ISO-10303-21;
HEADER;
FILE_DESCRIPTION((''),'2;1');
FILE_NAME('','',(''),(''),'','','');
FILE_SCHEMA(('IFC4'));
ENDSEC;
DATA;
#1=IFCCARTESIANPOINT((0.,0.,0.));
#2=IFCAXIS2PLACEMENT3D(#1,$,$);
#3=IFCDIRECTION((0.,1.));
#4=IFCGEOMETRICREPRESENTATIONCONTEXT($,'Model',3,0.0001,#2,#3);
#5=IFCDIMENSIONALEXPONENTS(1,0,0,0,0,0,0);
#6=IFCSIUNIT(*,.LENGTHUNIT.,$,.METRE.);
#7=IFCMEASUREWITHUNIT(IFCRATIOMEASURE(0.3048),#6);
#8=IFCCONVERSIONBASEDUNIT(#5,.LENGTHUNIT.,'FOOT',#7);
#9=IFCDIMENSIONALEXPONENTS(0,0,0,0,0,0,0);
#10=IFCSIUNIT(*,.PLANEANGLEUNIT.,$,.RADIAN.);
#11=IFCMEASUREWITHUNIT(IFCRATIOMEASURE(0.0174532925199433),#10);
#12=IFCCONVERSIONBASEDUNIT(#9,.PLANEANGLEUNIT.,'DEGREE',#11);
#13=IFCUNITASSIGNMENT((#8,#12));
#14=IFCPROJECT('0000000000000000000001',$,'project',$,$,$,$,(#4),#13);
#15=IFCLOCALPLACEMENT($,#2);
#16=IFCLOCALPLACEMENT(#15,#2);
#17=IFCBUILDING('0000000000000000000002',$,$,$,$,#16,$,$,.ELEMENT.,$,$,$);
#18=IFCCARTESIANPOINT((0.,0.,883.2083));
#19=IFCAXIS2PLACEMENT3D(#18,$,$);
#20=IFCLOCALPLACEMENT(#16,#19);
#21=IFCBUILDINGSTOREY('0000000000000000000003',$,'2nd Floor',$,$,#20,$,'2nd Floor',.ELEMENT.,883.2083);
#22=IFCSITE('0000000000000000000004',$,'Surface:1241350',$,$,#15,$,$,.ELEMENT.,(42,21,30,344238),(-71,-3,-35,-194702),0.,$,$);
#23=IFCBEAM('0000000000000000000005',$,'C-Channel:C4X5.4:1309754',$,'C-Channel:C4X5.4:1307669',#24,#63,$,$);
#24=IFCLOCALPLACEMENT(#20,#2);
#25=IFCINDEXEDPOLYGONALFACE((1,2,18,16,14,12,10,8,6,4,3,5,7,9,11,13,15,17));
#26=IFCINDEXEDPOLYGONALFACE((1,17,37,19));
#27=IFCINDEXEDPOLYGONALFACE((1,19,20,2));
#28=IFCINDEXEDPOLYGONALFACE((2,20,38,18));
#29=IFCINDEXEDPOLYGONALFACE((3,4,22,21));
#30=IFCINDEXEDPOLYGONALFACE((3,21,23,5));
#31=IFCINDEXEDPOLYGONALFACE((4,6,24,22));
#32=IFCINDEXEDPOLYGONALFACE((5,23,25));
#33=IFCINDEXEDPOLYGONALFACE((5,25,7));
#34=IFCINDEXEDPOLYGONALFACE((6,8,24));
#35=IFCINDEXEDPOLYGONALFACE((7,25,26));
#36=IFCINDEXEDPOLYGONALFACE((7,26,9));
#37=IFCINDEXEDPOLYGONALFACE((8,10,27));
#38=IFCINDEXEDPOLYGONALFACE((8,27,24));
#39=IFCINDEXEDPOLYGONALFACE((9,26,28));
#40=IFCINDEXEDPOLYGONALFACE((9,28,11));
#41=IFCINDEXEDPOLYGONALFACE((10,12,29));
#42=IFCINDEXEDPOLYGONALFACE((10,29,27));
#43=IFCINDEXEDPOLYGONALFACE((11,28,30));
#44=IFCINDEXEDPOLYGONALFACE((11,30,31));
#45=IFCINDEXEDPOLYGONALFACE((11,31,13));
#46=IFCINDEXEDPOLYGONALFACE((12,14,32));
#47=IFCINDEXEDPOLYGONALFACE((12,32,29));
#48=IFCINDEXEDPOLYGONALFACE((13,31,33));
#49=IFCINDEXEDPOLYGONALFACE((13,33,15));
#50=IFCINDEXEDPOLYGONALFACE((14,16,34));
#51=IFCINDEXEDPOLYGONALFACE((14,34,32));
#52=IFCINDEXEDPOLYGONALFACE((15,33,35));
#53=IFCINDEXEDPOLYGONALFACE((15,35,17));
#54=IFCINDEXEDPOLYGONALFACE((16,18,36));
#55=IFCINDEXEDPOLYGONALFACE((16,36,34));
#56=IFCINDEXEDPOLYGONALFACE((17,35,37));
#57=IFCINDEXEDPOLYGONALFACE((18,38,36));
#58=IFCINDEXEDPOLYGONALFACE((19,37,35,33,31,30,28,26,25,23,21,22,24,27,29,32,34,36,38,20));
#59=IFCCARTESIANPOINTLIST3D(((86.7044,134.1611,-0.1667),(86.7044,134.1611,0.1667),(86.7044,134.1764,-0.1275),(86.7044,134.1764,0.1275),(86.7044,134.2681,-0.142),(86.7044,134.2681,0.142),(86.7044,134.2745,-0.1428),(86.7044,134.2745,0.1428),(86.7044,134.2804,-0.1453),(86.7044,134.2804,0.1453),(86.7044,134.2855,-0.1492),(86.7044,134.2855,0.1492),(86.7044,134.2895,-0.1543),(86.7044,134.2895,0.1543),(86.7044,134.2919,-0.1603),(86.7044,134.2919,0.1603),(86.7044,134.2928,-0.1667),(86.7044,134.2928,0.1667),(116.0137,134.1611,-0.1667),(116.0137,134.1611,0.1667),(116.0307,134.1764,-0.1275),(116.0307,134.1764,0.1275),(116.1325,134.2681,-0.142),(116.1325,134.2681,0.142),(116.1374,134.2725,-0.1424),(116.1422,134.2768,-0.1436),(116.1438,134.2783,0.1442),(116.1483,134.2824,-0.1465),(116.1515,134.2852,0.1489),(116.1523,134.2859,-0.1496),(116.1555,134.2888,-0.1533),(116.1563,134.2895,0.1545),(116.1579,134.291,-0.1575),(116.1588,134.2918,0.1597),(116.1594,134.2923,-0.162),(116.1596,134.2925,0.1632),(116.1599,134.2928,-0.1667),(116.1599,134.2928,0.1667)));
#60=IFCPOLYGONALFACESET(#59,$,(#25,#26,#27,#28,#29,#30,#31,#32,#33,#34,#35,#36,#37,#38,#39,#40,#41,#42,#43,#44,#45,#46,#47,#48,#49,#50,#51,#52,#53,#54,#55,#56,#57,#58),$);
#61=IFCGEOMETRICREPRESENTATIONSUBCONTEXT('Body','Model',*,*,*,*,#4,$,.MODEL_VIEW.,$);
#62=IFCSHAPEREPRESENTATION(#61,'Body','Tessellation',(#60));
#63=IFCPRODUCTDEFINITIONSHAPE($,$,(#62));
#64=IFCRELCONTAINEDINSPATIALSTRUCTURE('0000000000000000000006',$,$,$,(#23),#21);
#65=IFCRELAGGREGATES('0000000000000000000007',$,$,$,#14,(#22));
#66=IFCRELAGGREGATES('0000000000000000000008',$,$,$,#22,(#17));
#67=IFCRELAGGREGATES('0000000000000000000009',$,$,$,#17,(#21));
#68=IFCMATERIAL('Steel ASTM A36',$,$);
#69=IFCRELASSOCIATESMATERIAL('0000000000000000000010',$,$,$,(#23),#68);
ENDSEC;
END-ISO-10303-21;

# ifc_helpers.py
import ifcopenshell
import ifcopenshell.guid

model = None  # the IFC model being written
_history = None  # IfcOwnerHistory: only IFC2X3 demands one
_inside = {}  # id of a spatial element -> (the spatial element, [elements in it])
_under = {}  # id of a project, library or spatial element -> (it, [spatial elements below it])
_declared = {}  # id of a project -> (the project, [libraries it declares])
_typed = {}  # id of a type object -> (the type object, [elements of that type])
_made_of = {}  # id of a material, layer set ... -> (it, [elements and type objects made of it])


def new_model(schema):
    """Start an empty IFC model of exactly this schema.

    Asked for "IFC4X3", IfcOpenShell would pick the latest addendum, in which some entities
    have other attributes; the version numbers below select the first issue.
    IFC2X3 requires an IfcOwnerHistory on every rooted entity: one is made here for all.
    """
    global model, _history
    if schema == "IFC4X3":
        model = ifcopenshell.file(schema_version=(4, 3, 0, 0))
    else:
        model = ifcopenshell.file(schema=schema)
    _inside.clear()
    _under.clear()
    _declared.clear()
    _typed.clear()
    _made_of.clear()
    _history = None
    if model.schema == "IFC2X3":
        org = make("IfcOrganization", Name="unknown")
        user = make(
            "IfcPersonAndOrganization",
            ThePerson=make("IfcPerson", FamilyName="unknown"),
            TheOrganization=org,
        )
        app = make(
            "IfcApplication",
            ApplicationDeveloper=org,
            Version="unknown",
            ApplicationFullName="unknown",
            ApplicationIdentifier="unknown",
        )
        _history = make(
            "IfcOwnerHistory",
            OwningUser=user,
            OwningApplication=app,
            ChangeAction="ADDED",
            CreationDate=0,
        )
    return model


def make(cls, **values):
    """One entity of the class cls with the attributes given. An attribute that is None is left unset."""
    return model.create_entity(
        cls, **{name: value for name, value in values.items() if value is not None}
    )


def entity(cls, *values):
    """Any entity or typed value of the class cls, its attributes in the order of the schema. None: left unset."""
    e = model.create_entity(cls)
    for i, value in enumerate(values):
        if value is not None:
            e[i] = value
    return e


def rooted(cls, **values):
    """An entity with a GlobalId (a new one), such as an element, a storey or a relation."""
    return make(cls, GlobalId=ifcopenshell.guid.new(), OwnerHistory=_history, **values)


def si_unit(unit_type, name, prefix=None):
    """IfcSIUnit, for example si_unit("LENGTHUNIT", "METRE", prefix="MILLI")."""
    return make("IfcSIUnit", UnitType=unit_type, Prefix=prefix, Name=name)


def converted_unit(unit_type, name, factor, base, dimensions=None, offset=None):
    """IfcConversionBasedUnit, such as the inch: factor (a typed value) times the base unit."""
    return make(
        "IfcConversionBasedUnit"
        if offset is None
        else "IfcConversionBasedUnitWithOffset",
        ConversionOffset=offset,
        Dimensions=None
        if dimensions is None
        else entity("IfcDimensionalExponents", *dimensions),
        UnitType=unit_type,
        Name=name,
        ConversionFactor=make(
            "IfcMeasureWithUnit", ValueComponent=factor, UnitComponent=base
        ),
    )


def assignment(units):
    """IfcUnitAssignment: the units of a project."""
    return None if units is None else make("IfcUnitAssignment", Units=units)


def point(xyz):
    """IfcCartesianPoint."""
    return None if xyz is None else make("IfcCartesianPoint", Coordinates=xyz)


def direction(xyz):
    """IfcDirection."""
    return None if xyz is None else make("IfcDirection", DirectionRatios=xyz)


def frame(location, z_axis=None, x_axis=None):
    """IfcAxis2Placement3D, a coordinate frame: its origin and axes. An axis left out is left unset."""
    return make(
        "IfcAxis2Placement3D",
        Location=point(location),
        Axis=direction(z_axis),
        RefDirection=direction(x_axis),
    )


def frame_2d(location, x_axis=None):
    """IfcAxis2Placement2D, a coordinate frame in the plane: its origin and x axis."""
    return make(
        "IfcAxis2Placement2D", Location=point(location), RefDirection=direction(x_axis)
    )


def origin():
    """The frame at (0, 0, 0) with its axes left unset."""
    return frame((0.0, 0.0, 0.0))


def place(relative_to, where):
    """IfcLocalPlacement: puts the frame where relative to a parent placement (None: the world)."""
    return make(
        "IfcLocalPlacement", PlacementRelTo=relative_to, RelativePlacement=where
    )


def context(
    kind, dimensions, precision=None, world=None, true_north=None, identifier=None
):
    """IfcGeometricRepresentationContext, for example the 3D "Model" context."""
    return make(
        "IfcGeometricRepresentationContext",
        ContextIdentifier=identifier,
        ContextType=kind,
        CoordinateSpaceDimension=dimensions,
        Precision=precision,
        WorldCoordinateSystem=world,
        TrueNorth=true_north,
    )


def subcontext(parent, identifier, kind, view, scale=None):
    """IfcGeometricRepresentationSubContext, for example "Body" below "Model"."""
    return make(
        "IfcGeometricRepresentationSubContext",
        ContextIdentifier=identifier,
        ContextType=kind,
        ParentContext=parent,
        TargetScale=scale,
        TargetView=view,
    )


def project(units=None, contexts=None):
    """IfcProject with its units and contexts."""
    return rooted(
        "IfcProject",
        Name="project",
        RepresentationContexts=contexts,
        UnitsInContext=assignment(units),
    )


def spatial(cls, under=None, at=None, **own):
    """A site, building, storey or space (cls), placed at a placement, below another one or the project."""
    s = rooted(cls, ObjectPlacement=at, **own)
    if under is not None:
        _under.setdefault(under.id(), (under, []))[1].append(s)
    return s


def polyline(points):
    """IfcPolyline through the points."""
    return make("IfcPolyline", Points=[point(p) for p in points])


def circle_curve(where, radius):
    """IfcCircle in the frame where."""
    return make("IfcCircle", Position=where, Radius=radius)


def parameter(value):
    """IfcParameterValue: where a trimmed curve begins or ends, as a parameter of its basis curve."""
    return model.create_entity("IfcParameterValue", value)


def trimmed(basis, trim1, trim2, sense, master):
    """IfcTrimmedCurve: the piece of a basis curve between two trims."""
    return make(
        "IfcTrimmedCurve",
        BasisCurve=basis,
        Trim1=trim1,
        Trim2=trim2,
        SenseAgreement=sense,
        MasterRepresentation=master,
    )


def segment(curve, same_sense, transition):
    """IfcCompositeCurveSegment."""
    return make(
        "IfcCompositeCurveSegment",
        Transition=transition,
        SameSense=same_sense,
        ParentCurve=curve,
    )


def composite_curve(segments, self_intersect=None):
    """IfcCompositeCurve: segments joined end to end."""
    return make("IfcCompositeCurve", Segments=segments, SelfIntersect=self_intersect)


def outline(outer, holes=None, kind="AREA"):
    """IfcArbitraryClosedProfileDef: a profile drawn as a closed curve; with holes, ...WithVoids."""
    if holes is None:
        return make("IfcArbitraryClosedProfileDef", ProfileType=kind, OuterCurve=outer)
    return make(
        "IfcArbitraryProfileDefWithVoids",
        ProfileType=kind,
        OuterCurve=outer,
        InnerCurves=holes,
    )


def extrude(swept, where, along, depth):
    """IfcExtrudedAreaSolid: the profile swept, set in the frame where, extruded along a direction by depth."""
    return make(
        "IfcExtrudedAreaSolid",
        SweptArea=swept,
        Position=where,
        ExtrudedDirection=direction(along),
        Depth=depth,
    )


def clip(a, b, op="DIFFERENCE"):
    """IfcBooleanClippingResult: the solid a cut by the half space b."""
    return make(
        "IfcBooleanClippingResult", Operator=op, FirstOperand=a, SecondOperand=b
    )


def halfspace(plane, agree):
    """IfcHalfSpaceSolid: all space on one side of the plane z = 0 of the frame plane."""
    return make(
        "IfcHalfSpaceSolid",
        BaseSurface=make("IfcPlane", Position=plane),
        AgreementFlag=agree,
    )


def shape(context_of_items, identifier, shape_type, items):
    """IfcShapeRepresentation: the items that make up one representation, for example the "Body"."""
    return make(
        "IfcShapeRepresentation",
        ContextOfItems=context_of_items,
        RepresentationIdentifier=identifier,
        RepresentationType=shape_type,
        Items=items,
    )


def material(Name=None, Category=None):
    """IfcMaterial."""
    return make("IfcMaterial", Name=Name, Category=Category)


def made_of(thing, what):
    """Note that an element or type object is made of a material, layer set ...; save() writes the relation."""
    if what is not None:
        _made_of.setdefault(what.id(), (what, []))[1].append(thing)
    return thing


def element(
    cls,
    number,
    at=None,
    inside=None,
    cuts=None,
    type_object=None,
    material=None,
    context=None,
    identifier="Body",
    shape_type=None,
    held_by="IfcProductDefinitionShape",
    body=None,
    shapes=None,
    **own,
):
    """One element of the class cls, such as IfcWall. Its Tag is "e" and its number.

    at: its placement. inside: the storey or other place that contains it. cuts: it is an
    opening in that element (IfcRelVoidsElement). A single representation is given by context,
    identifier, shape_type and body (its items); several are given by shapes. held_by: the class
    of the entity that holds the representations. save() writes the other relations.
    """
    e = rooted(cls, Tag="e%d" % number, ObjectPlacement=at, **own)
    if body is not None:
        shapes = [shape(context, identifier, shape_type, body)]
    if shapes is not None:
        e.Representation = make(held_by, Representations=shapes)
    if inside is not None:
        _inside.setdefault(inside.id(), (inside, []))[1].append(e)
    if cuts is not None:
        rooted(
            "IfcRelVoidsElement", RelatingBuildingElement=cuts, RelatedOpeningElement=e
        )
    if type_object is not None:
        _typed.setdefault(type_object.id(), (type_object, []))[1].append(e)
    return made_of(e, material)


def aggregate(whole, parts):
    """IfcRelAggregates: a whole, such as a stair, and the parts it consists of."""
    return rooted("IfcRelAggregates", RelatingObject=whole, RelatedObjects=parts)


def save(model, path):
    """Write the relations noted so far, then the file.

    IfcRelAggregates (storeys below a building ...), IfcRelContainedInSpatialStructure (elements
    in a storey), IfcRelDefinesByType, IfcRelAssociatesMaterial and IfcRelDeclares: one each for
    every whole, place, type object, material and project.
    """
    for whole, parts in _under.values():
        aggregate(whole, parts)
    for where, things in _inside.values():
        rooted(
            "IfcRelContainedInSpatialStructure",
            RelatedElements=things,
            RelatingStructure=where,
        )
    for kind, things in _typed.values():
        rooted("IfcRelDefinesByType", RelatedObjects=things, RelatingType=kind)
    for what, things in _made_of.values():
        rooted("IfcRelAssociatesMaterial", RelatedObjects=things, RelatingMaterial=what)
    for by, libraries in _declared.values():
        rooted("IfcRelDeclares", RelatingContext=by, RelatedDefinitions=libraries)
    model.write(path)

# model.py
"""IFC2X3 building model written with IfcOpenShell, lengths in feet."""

from ifc_helpers import new_model, entity, si_unit, converted_unit, direction, frame, frame_2d, origin, place, context, subcontext, project, spatial, polyline, circle_curve, parameter, trimmed, segment, composite_curve, outline, extrude, clip, halfspace, material, element, save


model = new_model("IFC2X3")

# Units and contexts
model_context = context("Model", 3, precision=0.0001, world=origin(), true_north=direction((0.0, 1.0)))
body_context = subcontext(model_context, "Body", "Model", "MODEL_VIEW")
ifc_project = project(units=[converted_unit("LENGTHUNIT", "FOOT", entity("IfcRatioMeasure", 0.3048), si_unit("LENGTHUNIT", "METRE"), dimensions=[1, 0, 0, 0, 0, 0, 0]), converted_unit("PLANEANGLEUNIT", "DEGREE", entity("IfcRatioMeasure", 0.0174532925199433), si_unit("PLANEANGLEUNIT", "RADIAN"), dimensions=[0, 0, 0, 0, 0, 0, 0])], contexts=[model_context])

# Site, building, storey
site_placement = place(None, origin())
site = spatial("IfcSite", under=ifc_project, at=site_placement, Name="Surface:1241350", CompositionType="ELEMENT", RefLatitude=(42, 21, 30, 344238), RefLongitude=(-71, -3, -35, -194702), RefElevation=0.0)
building_placement = place(site_placement, origin())
building = spatial("IfcBuilding", under=site, at=building_placement, CompositionType="ELEMENT")
storey_placement = place(building_placement, frame((0.0, 0.0, 883.2083)))
storey = spatial("IfcBuildingStorey", under=building, at=storey_placement, Name="2nd Floor", LongName="2nd Floor", CompositionType="ELEMENT", Elevation=883.2083)

# Beam
ifc_material_1 = material(Name="Steel ASTM A36")
beam_1_placement = place(storey_placement, frame((86.7044, 134.1992, 0.0)))
element("IfcBeam", 1, at=beam_1_placement, inside=storey, material=ifc_material_1, Name="C-Channel:C4X5.4:1309754", ObjectType="C-Channel:C4X5.4:1307669", context=body_context, shape_type="Clipping", body=[
    clip(extrude(outline(composite_curve([segment(polyline([(-0.1667, -0.0635), (0.1667, -0.0635)]), True, "CONTINUOUS"), segment(polyline([(0.1667, -0.0635), (0.1667, 0.0682)]), True, "CONTINUOUS"), segment(trimmed(circle_curve(frame_2d((0.1667, 0.0435), x_axis=(0.0, 1.0)), 0.0247), [parameter(0.0)], [parameter(90.0)], True, "PARAMETER"), True, "CONTINUOUS"), segment(polyline([(0.142, 0.0435), (0.1275, -0.0482)]), True, "CONTINUOUS"), segment(polyline([(0.1275, -0.0482), (-0.1275, -0.0482)]), True, "CONTINUOUS"), segment(polyline([(-0.1275, -0.0482), (-0.142, 0.0435)]), True, "CONTINUOUS"), segment(trimmed(circle_curve(frame_2d((-0.1667, 0.0435), x_axis=(1.0, 0.0)), 0.0247), [parameter(0.0)], [parameter(90.0)], True, "PARAMETER"), True, "CONTINUOUS"), segment(polyline([(-0.1667, 0.0682), (-0.1667, -0.0635)]), True, "CONTINUOUS")], self_intersect=False)), frame((0.0, 0.0254, 0.0), z_axis=(1.0, 0.0, 0.0), x_axis=(0.0, 0.0, -1.0)), (0.0, 0.0, 1.0), 29.4555), halfspace(frame((29.3093, -0.0381, 0.0), z_axis=(0.669131, -0.743145, 0.0), x_axis=(0.743145, 0.669131, 0.0)), False)),
])

save(model, "model.ifc")
